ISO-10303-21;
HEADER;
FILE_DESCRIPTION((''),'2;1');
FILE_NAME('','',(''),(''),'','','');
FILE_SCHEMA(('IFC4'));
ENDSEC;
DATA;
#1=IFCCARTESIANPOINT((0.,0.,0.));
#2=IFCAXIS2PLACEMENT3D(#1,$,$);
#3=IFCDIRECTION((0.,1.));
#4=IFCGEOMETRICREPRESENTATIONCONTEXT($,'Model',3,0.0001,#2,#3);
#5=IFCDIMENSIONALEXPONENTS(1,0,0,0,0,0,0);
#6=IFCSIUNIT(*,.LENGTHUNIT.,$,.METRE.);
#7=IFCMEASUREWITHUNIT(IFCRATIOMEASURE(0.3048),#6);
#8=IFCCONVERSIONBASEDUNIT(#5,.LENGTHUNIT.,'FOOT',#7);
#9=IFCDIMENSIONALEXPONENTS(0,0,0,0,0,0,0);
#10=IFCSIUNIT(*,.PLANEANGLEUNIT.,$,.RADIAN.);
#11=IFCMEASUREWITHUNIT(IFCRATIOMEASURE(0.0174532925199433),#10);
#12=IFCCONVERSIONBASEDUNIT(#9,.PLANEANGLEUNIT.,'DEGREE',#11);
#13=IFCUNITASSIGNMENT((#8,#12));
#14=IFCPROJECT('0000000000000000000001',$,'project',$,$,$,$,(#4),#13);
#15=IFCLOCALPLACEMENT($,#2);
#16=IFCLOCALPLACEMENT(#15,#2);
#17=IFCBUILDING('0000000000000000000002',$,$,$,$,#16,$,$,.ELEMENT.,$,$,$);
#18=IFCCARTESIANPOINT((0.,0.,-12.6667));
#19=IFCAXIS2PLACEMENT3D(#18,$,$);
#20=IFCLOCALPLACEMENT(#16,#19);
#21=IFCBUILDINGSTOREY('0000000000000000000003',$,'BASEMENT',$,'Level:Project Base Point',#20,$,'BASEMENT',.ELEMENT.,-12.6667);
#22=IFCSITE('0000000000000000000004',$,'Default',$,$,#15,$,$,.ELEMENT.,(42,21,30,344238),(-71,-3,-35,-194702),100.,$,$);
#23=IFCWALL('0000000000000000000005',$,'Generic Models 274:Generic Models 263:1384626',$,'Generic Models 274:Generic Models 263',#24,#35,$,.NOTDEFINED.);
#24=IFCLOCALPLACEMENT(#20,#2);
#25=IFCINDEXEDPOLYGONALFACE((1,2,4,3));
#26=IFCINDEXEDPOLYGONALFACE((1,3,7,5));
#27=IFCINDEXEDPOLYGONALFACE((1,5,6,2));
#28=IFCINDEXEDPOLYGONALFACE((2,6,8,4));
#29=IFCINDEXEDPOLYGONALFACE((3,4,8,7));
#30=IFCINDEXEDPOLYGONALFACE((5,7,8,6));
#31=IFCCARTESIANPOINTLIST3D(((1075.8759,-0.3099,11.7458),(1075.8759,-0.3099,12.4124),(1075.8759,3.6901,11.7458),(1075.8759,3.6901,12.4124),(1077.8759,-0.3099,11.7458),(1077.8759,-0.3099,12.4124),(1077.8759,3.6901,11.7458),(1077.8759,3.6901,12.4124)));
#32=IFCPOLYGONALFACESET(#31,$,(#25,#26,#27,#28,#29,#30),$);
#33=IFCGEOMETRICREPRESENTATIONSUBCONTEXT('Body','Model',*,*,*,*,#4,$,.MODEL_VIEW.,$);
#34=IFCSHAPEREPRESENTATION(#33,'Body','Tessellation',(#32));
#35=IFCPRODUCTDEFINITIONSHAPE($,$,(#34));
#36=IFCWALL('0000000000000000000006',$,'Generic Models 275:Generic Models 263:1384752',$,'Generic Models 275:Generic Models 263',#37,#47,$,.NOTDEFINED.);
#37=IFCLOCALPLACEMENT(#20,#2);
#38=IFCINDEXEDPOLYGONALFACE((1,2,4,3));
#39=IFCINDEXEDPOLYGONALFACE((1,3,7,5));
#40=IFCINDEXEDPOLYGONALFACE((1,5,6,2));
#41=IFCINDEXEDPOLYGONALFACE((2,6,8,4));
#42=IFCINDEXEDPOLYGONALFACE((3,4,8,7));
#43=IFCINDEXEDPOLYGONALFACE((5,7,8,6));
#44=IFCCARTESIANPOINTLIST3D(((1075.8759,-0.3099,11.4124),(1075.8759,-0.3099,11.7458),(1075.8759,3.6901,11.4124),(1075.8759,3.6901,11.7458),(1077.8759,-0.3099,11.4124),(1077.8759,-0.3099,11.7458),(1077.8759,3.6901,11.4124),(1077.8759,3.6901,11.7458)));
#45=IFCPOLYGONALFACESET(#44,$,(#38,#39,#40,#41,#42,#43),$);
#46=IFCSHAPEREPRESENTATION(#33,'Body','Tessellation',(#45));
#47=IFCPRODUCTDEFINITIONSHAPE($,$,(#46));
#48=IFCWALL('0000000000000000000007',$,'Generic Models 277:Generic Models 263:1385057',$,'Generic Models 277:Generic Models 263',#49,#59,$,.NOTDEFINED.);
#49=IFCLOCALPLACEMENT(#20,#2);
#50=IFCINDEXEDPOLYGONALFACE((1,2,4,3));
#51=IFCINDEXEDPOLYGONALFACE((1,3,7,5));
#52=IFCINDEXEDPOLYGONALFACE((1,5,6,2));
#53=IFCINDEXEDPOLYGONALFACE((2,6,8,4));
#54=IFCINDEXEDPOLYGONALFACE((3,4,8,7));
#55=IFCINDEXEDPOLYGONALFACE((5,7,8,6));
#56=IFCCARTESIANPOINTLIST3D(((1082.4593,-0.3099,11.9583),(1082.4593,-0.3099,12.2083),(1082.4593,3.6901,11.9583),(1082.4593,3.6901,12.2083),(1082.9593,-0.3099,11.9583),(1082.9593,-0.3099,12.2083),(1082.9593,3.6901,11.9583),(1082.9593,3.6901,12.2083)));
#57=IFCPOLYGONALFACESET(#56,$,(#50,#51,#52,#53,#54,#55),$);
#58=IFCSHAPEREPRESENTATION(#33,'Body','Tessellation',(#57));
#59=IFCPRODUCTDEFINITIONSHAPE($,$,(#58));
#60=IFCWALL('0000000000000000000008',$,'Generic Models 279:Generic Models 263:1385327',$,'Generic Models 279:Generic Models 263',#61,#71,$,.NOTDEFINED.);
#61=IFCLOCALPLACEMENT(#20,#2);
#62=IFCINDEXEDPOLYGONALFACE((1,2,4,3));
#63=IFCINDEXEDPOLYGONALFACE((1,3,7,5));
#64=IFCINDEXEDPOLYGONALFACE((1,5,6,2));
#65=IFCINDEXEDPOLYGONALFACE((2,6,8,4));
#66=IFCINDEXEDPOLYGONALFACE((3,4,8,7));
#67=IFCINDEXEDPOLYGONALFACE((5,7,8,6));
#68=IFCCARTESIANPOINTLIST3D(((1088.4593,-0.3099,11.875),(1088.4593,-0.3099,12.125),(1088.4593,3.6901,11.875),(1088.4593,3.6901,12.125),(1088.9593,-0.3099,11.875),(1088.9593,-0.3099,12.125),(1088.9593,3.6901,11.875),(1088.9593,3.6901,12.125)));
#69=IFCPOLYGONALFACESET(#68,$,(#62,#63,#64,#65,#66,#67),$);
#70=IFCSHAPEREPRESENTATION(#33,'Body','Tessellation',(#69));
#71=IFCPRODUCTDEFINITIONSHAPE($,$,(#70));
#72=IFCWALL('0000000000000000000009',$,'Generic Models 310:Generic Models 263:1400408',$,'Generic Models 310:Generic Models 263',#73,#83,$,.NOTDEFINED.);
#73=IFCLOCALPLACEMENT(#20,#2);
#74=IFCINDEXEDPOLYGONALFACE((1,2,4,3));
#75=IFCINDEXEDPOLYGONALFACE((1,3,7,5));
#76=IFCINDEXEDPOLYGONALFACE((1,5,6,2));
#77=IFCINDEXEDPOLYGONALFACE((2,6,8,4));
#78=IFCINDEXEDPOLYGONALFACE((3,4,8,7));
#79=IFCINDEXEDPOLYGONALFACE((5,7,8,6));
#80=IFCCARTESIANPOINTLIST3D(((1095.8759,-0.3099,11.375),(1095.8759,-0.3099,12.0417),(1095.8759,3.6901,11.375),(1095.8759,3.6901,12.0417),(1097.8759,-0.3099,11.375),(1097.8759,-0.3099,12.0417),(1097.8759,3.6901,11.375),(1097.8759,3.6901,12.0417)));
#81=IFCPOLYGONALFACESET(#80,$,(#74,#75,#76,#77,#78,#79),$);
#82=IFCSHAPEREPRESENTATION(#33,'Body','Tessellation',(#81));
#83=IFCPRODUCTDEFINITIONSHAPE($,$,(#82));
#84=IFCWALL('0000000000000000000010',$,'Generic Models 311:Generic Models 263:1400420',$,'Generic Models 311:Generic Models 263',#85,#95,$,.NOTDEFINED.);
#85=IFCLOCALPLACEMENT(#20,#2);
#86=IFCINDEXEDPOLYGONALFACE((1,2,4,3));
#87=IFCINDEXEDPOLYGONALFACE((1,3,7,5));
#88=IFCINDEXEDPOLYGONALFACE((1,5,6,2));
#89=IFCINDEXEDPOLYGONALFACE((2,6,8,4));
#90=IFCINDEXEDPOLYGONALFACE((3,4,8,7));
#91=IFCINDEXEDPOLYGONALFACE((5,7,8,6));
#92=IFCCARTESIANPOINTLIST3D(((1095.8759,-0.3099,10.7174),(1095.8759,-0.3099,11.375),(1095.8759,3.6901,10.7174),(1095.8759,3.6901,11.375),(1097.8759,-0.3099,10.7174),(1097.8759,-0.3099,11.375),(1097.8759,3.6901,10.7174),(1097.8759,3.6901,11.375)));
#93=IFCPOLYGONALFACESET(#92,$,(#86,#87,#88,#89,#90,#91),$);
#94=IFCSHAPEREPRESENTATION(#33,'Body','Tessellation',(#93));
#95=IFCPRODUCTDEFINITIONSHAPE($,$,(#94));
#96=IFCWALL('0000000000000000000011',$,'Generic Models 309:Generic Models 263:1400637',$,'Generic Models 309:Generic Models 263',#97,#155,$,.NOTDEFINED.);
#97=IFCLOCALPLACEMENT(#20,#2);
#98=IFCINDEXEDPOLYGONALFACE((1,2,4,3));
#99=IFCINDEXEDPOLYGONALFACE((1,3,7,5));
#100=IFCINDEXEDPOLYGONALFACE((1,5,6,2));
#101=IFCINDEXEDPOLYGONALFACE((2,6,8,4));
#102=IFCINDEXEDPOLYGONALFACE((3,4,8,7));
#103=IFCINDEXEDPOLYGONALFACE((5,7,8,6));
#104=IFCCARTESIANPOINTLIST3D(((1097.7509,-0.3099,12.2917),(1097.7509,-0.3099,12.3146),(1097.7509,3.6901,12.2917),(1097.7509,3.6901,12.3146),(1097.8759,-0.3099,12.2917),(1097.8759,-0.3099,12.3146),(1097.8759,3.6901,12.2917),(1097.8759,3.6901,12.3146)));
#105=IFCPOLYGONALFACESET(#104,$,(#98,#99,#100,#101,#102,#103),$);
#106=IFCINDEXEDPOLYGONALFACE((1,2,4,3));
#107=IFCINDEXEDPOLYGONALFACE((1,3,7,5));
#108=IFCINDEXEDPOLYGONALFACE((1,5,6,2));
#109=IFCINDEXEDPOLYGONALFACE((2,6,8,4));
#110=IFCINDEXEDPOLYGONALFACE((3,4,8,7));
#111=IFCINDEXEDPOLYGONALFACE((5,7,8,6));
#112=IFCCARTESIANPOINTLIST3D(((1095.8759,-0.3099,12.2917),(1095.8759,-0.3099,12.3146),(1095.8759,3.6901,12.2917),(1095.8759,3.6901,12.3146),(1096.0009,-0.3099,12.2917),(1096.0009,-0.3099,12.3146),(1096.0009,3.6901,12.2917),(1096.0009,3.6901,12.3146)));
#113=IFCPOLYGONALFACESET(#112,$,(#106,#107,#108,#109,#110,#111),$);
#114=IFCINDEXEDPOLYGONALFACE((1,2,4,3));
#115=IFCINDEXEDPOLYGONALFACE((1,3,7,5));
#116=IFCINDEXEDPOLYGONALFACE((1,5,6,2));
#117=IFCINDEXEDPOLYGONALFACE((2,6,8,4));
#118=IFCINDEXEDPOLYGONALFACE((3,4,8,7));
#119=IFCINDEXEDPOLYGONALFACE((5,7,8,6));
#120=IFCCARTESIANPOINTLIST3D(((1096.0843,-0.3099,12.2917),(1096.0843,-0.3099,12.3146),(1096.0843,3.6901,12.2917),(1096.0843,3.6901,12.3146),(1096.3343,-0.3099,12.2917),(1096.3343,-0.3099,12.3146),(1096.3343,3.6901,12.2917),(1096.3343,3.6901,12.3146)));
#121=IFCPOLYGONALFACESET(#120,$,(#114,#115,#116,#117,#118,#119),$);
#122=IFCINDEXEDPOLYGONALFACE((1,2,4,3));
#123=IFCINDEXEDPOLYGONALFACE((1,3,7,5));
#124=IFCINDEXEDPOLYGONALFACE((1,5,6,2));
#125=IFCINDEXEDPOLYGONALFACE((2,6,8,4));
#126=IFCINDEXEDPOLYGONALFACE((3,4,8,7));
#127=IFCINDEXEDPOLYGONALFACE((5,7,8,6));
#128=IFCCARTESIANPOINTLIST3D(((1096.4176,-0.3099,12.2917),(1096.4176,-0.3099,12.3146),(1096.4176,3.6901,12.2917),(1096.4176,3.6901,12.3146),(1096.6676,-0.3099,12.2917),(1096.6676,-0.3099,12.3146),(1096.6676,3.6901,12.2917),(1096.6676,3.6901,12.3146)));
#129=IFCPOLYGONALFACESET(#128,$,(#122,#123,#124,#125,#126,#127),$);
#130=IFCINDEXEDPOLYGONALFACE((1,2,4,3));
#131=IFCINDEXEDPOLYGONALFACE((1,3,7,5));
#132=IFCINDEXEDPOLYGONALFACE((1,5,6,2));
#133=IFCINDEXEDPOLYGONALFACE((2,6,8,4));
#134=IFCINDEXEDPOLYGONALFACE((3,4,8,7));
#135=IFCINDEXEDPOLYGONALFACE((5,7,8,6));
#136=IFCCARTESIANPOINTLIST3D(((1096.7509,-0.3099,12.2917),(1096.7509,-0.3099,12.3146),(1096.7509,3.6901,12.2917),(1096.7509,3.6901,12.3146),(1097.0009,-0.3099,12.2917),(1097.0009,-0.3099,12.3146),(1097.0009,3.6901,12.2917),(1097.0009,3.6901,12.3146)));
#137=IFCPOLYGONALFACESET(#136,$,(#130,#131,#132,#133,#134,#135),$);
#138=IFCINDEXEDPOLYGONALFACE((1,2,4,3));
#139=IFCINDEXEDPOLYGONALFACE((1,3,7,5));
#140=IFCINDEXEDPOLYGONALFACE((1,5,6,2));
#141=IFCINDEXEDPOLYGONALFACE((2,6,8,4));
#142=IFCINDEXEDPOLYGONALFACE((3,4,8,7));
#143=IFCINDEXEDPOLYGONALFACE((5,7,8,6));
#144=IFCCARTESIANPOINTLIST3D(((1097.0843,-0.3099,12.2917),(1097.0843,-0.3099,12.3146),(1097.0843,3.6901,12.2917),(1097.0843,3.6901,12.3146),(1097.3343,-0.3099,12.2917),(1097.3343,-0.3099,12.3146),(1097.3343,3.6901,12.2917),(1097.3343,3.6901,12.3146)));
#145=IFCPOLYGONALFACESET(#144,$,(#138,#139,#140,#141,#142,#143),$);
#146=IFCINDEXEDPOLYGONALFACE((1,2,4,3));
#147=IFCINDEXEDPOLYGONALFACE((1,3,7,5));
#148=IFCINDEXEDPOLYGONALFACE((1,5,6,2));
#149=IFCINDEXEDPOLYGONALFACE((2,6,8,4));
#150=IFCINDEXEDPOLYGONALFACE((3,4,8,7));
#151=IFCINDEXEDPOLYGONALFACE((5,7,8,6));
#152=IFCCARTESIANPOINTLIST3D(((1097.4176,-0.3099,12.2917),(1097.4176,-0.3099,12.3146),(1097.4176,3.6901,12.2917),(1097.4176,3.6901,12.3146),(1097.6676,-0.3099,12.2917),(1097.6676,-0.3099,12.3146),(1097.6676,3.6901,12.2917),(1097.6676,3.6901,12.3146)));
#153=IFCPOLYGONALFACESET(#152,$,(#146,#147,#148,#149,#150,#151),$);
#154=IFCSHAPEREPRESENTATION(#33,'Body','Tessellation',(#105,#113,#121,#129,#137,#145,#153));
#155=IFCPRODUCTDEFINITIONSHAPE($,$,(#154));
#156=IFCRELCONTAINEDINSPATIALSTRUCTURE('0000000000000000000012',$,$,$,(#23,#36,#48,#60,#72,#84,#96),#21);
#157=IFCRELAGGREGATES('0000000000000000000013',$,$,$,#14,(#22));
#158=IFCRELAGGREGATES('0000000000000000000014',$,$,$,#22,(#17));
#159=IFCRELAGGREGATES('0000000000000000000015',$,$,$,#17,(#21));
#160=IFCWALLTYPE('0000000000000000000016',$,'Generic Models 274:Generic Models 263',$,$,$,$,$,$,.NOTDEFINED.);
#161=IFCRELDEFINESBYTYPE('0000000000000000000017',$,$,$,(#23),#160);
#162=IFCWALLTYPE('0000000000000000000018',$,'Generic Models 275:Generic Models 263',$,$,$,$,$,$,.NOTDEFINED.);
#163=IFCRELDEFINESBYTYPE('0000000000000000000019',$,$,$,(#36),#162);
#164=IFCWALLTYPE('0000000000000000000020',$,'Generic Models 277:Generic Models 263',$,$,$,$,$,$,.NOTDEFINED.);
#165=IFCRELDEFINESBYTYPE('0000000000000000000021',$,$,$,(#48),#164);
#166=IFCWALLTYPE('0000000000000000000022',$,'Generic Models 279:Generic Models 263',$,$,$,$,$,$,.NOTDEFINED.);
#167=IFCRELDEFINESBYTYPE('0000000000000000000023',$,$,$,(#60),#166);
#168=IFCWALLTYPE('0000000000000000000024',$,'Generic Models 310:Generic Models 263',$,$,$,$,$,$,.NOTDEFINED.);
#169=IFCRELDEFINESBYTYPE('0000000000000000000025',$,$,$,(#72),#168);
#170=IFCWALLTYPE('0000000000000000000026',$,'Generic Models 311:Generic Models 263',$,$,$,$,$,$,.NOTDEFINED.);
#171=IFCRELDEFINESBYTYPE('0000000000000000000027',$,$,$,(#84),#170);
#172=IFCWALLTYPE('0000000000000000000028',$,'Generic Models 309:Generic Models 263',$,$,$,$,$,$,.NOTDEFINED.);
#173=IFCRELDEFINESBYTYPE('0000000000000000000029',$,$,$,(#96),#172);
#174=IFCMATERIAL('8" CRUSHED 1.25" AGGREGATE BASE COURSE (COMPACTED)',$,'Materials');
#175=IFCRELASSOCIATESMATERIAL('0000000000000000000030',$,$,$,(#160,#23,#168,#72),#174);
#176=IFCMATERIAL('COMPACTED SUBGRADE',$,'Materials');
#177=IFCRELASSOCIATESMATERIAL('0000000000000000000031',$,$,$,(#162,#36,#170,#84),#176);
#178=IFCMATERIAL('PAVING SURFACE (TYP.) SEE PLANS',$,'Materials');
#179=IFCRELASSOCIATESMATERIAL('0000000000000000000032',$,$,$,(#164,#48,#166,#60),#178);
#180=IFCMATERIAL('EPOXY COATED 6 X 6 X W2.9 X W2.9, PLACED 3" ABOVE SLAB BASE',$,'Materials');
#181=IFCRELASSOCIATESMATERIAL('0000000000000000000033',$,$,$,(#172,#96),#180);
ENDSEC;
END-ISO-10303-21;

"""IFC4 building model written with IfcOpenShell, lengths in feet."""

from ifc_helpers import new_model, entity, si_unit, converted_unit, direction, frame, origin, origin_2d_with_axis, place, context, subcontext, project, spatial, rectangle, extrude, material, type_object, element, save


model = new_model("IFC4")

# Units and contexts
model_context = context("Model", 3, precision=0.0001, world=origin(), true_north=direction((0.0, 1.0)))
body_context = subcontext(model_context, "Body", "Model", "MODEL_VIEW")
ifc_project = project(units=[converted_unit("LENGTHUNIT", "FOOT", entity("IfcRatioMeasure", 0.3048), si_unit("LENGTHUNIT", "METRE"), dimensions=[1, 0, 0, 0, 0, 0, 0]), converted_unit("PLANEANGLEUNIT", "DEGREE", entity("IfcRatioMeasure", 0.0174532925199433), si_unit("PLANEANGLEUNIT", "RADIAN"), dimensions=[0, 0, 0, 0, 0, 0, 0])], contexts=[model_context])

# Site, building, storey
site_placement = place(None, origin())
site = spatial("IfcSite", under=ifc_project, at=site_placement, Name="Default", CompositionType="ELEMENT", RefLatitude=(42, 21, 30, 344238), RefLongitude=(-71, -3, -35, -194702), RefElevation=100.0)
building_placement = place(site_placement, origin())
building = spatial("IfcBuilding", under=site, at=building_placement, CompositionType="ELEMENT")
storey_placement = place(building_placement, frame((0.0, 0.0, -12.6667)))
storey = spatial("IfcBuildingStorey", under=building, at=storey_placement, Name="BASEMENT", ObjectType="Level:Project Base Point", LongName="BASEMENT", CompositionType="ELEMENT", Elevation=-12.6667)

# Walls
ifc_material_1 = material(Name="8\" CRUSHED 1.25\" AGGREGATE BASE COURSE (COMPACTED)", Category="Materials")
wall_type_1 = type_object("IfcWallType", Name="Generic Models 274:Generic Models 263", PredefinedType="NOTDEFINED", material=ifc_material_1)
wall_1_placement = place(storey_placement, frame((1075.8759, -0.3099, 11.7458), z_axis=(0.0, 0.0, 1.0), x_axis=(0.0, 1.0, 0.0)))
element("IfcWall", 1, at=wall_1_placement, inside=storey, type_object=wall_type_1, material=ifc_material_1, Name="Generic Models 274:Generic Models 263:1384626", ObjectType="Generic Models 274:Generic Models 263", PredefinedType="NOTDEFINED", context=body_context, shape_type="SweptSolid", body=[
    extrude(rectangle(XDim=4.0, YDim=2.0, at=origin_2d_with_axis()), frame((2.0, -1.0, 0.0)), (0.0, 0.0, 1.0), 0.6667),
])
ifc_material_2 = material(Name="COMPACTED SUBGRADE", Category="Materials")
wall_type_2 = type_object("IfcWallType", Name="Generic Models 275:Generic Models 263", PredefinedType="NOTDEFINED", material=ifc_material_2)
wall_2_placement = place(storey_placement, frame((1075.8759, -0.3099, 11.4124), z_axis=(0.0, 0.0, 1.0), x_axis=(0.0, 1.0, 0.0)))
element("IfcWall", 2, at=wall_2_placement, inside=storey, type_object=wall_type_2, material=ifc_material_2, Name="Generic Models 275:Generic Models 263:1384752", ObjectType="Generic Models 275:Generic Models 263", PredefinedType="NOTDEFINED", context=body_context, shape_type="SweptSolid", body=[
    extrude(rectangle(XDim=4.0, YDim=2.0, at=origin_2d_with_axis()), frame((2.0, -1.0, 0.0)), (0.0, 0.0, 1.0), 0.3333),
])
ifc_material_3 = material(Name="PAVING SURFACE (TYP.) SEE PLANS", Category="Materials")
wall_type_3 = type_object("IfcWallType", Name="Generic Models 277:Generic Models 263", PredefinedType="NOTDEFINED", material=ifc_material_3)
wall_3_placement = place(storey_placement, frame((1082.4593, -0.3099, 11.9583), z_axis=(0.0, 0.0, 1.0), x_axis=(0.0, 1.0, 0.0)))
element("IfcWall", 3, at=wall_3_placement, inside=storey, type_object=wall_type_3, material=ifc_material_3, Name="Generic Models 277:Generic Models 263:1385057", ObjectType="Generic Models 277:Generic Models 263", PredefinedType="NOTDEFINED", context=body_context, shape_type="SweptSolid", body=[
    extrude(rectangle(XDim=4.0, YDim=0.5, at=origin_2d_with_axis()), frame((2.0, -0.25, 0.0)), (0.0, 0.0, 1.0), 0.25),
])
wall_type_4 = type_object("IfcWallType", Name="Generic Models 279:Generic Models 263", PredefinedType="NOTDEFINED", material=ifc_material_3)
wall_4_placement = place(storey_placement, frame((1088.4593, -0.3099, 11.875), z_axis=(0.0, 0.0, 1.0), x_axis=(0.0, 1.0, 0.0)))
element("IfcWall", 4, at=wall_4_placement, inside=storey, type_object=wall_type_4, material=ifc_material_3, Name="Generic Models 279:Generic Models 263:1385327", ObjectType="Generic Models 279:Generic Models 263", PredefinedType="NOTDEFINED", context=body_context, shape_type="SweptSolid", body=[
    extrude(rectangle(XDim=4.0, YDim=0.5, at=origin_2d_with_axis()), frame((2.0, -0.25, 0.0)), (0.0, 0.0, 1.0), 0.25),
])
wall_type_5 = type_object("IfcWallType", Name="Generic Models 310:Generic Models 263", PredefinedType="NOTDEFINED", material=ifc_material_1)
wall_5_placement = place(storey_placement, frame((1095.8759, -0.3099, 11.375), z_axis=(0.0, 0.0, 1.0), x_axis=(0.0, 1.0, 0.0)))
element("IfcWall", 5, at=wall_5_placement, inside=storey, type_object=wall_type_5, material=ifc_material_1, Name="Generic Models 310:Generic Models 263:1400408", ObjectType="Generic Models 310:Generic Models 263", PredefinedType="NOTDEFINED", context=body_context, shape_type="SweptSolid", body=[
    extrude(rectangle(XDim=4.0, YDim=2.0, at=origin_2d_with_axis()), frame((2.0, -1.0, 0.0)), (0.0, 0.0, 1.0), 0.6667),
])
wall_type_6 = type_object("IfcWallType", Name="Generic Models 311:Generic Models 263", PredefinedType="NOTDEFINED", material=ifc_material_2)
wall_6_placement = place(storey_placement, frame((1095.8759, -0.3099, 10.7174), z_axis=(0.0, 0.0, 1.0), x_axis=(0.0, 1.0, 0.0)))
element("IfcWall", 6, at=wall_6_placement, inside=storey, type_object=wall_type_6, material=ifc_material_2, Name="Generic Models 311:Generic Models 263:1400420", ObjectType="Generic Models 311:Generic Models 263", PredefinedType="NOTDEFINED", context=body_context, shape_type="SweptSolid", body=[
    extrude(rectangle(XDim=4.0, YDim=2.0, at=origin_2d_with_axis()), frame((2.0, -1.0, 0.0)), (0.0, 0.0, 1.0), 0.6576),
])
ifc_material_4 = material(Name="EPOXY COATED 6 X 6 X W2.9 X W2.9, PLACED 3\" ABOVE SLAB BASE", Category="Materials")
wall_type_7 = type_object("IfcWallType", Name="Generic Models 309:Generic Models 263", PredefinedType="NOTDEFINED", material=ifc_material_4)
wall_7_placement = place(storey_placement, frame((1095.8759, -0.3099, 12.2917), z_axis=(0.0, 0.0, 1.0), x_axis=(0.0, 1.0, 0.0)))
element("IfcWall", 7, at=wall_7_placement, inside=storey, type_object=wall_type_7, material=ifc_material_4, Name="Generic Models 309:Generic Models 263:1400637", ObjectType="Generic Models 309:Generic Models 263", PredefinedType="NOTDEFINED", context=body_context, shape_type="SweptSolid", body=[
    extrude(rectangle(XDim=4.0, YDim=0.125, at=origin_2d_with_axis()), frame((2.0, -1.9375, 0.0)), (0.0, 0.0, 1.0), 0.023),
    extrude(rectangle(XDim=4.0, YDim=0.125, at=origin_2d_with_axis()), frame((2.0, -0.0625, 0.0)), (0.0, 0.0, 1.0), 0.023),
    extrude(rectangle(XDim=4.0, YDim=0.25, at=origin_2d_with_axis()), frame((2.0, -0.3333, 0.0)), (0.0, 0.0, 1.0), 0.023),
    extrude(rectangle(XDim=4.0, YDim=0.25, at=origin_2d_with_axis()), frame((2.0, -0.6667, 0.0)), (0.0, 0.0, 1.0), 0.023),
    extrude(rectangle(XDim=4.0, YDim=0.25, at=origin_2d_with_axis()), frame((2.0, -1.0, 0.0)), (0.0, 0.0, 1.0), 0.023),
    extrude(rectangle(XDim=4.0, YDim=0.25, at=origin_2d_with_axis()), frame((2.0, -1.3333, 0.0)), (0.0, 0.0, 1.0), 0.023),
    extrude(rectangle(XDim=4.0, YDim=0.25, at=origin_2d_with_axis()), frame((2.0, -1.6667, 0.0)), (0.0, 0.0, 1.0), 0.023),
])

save(model, "model.ifc")
